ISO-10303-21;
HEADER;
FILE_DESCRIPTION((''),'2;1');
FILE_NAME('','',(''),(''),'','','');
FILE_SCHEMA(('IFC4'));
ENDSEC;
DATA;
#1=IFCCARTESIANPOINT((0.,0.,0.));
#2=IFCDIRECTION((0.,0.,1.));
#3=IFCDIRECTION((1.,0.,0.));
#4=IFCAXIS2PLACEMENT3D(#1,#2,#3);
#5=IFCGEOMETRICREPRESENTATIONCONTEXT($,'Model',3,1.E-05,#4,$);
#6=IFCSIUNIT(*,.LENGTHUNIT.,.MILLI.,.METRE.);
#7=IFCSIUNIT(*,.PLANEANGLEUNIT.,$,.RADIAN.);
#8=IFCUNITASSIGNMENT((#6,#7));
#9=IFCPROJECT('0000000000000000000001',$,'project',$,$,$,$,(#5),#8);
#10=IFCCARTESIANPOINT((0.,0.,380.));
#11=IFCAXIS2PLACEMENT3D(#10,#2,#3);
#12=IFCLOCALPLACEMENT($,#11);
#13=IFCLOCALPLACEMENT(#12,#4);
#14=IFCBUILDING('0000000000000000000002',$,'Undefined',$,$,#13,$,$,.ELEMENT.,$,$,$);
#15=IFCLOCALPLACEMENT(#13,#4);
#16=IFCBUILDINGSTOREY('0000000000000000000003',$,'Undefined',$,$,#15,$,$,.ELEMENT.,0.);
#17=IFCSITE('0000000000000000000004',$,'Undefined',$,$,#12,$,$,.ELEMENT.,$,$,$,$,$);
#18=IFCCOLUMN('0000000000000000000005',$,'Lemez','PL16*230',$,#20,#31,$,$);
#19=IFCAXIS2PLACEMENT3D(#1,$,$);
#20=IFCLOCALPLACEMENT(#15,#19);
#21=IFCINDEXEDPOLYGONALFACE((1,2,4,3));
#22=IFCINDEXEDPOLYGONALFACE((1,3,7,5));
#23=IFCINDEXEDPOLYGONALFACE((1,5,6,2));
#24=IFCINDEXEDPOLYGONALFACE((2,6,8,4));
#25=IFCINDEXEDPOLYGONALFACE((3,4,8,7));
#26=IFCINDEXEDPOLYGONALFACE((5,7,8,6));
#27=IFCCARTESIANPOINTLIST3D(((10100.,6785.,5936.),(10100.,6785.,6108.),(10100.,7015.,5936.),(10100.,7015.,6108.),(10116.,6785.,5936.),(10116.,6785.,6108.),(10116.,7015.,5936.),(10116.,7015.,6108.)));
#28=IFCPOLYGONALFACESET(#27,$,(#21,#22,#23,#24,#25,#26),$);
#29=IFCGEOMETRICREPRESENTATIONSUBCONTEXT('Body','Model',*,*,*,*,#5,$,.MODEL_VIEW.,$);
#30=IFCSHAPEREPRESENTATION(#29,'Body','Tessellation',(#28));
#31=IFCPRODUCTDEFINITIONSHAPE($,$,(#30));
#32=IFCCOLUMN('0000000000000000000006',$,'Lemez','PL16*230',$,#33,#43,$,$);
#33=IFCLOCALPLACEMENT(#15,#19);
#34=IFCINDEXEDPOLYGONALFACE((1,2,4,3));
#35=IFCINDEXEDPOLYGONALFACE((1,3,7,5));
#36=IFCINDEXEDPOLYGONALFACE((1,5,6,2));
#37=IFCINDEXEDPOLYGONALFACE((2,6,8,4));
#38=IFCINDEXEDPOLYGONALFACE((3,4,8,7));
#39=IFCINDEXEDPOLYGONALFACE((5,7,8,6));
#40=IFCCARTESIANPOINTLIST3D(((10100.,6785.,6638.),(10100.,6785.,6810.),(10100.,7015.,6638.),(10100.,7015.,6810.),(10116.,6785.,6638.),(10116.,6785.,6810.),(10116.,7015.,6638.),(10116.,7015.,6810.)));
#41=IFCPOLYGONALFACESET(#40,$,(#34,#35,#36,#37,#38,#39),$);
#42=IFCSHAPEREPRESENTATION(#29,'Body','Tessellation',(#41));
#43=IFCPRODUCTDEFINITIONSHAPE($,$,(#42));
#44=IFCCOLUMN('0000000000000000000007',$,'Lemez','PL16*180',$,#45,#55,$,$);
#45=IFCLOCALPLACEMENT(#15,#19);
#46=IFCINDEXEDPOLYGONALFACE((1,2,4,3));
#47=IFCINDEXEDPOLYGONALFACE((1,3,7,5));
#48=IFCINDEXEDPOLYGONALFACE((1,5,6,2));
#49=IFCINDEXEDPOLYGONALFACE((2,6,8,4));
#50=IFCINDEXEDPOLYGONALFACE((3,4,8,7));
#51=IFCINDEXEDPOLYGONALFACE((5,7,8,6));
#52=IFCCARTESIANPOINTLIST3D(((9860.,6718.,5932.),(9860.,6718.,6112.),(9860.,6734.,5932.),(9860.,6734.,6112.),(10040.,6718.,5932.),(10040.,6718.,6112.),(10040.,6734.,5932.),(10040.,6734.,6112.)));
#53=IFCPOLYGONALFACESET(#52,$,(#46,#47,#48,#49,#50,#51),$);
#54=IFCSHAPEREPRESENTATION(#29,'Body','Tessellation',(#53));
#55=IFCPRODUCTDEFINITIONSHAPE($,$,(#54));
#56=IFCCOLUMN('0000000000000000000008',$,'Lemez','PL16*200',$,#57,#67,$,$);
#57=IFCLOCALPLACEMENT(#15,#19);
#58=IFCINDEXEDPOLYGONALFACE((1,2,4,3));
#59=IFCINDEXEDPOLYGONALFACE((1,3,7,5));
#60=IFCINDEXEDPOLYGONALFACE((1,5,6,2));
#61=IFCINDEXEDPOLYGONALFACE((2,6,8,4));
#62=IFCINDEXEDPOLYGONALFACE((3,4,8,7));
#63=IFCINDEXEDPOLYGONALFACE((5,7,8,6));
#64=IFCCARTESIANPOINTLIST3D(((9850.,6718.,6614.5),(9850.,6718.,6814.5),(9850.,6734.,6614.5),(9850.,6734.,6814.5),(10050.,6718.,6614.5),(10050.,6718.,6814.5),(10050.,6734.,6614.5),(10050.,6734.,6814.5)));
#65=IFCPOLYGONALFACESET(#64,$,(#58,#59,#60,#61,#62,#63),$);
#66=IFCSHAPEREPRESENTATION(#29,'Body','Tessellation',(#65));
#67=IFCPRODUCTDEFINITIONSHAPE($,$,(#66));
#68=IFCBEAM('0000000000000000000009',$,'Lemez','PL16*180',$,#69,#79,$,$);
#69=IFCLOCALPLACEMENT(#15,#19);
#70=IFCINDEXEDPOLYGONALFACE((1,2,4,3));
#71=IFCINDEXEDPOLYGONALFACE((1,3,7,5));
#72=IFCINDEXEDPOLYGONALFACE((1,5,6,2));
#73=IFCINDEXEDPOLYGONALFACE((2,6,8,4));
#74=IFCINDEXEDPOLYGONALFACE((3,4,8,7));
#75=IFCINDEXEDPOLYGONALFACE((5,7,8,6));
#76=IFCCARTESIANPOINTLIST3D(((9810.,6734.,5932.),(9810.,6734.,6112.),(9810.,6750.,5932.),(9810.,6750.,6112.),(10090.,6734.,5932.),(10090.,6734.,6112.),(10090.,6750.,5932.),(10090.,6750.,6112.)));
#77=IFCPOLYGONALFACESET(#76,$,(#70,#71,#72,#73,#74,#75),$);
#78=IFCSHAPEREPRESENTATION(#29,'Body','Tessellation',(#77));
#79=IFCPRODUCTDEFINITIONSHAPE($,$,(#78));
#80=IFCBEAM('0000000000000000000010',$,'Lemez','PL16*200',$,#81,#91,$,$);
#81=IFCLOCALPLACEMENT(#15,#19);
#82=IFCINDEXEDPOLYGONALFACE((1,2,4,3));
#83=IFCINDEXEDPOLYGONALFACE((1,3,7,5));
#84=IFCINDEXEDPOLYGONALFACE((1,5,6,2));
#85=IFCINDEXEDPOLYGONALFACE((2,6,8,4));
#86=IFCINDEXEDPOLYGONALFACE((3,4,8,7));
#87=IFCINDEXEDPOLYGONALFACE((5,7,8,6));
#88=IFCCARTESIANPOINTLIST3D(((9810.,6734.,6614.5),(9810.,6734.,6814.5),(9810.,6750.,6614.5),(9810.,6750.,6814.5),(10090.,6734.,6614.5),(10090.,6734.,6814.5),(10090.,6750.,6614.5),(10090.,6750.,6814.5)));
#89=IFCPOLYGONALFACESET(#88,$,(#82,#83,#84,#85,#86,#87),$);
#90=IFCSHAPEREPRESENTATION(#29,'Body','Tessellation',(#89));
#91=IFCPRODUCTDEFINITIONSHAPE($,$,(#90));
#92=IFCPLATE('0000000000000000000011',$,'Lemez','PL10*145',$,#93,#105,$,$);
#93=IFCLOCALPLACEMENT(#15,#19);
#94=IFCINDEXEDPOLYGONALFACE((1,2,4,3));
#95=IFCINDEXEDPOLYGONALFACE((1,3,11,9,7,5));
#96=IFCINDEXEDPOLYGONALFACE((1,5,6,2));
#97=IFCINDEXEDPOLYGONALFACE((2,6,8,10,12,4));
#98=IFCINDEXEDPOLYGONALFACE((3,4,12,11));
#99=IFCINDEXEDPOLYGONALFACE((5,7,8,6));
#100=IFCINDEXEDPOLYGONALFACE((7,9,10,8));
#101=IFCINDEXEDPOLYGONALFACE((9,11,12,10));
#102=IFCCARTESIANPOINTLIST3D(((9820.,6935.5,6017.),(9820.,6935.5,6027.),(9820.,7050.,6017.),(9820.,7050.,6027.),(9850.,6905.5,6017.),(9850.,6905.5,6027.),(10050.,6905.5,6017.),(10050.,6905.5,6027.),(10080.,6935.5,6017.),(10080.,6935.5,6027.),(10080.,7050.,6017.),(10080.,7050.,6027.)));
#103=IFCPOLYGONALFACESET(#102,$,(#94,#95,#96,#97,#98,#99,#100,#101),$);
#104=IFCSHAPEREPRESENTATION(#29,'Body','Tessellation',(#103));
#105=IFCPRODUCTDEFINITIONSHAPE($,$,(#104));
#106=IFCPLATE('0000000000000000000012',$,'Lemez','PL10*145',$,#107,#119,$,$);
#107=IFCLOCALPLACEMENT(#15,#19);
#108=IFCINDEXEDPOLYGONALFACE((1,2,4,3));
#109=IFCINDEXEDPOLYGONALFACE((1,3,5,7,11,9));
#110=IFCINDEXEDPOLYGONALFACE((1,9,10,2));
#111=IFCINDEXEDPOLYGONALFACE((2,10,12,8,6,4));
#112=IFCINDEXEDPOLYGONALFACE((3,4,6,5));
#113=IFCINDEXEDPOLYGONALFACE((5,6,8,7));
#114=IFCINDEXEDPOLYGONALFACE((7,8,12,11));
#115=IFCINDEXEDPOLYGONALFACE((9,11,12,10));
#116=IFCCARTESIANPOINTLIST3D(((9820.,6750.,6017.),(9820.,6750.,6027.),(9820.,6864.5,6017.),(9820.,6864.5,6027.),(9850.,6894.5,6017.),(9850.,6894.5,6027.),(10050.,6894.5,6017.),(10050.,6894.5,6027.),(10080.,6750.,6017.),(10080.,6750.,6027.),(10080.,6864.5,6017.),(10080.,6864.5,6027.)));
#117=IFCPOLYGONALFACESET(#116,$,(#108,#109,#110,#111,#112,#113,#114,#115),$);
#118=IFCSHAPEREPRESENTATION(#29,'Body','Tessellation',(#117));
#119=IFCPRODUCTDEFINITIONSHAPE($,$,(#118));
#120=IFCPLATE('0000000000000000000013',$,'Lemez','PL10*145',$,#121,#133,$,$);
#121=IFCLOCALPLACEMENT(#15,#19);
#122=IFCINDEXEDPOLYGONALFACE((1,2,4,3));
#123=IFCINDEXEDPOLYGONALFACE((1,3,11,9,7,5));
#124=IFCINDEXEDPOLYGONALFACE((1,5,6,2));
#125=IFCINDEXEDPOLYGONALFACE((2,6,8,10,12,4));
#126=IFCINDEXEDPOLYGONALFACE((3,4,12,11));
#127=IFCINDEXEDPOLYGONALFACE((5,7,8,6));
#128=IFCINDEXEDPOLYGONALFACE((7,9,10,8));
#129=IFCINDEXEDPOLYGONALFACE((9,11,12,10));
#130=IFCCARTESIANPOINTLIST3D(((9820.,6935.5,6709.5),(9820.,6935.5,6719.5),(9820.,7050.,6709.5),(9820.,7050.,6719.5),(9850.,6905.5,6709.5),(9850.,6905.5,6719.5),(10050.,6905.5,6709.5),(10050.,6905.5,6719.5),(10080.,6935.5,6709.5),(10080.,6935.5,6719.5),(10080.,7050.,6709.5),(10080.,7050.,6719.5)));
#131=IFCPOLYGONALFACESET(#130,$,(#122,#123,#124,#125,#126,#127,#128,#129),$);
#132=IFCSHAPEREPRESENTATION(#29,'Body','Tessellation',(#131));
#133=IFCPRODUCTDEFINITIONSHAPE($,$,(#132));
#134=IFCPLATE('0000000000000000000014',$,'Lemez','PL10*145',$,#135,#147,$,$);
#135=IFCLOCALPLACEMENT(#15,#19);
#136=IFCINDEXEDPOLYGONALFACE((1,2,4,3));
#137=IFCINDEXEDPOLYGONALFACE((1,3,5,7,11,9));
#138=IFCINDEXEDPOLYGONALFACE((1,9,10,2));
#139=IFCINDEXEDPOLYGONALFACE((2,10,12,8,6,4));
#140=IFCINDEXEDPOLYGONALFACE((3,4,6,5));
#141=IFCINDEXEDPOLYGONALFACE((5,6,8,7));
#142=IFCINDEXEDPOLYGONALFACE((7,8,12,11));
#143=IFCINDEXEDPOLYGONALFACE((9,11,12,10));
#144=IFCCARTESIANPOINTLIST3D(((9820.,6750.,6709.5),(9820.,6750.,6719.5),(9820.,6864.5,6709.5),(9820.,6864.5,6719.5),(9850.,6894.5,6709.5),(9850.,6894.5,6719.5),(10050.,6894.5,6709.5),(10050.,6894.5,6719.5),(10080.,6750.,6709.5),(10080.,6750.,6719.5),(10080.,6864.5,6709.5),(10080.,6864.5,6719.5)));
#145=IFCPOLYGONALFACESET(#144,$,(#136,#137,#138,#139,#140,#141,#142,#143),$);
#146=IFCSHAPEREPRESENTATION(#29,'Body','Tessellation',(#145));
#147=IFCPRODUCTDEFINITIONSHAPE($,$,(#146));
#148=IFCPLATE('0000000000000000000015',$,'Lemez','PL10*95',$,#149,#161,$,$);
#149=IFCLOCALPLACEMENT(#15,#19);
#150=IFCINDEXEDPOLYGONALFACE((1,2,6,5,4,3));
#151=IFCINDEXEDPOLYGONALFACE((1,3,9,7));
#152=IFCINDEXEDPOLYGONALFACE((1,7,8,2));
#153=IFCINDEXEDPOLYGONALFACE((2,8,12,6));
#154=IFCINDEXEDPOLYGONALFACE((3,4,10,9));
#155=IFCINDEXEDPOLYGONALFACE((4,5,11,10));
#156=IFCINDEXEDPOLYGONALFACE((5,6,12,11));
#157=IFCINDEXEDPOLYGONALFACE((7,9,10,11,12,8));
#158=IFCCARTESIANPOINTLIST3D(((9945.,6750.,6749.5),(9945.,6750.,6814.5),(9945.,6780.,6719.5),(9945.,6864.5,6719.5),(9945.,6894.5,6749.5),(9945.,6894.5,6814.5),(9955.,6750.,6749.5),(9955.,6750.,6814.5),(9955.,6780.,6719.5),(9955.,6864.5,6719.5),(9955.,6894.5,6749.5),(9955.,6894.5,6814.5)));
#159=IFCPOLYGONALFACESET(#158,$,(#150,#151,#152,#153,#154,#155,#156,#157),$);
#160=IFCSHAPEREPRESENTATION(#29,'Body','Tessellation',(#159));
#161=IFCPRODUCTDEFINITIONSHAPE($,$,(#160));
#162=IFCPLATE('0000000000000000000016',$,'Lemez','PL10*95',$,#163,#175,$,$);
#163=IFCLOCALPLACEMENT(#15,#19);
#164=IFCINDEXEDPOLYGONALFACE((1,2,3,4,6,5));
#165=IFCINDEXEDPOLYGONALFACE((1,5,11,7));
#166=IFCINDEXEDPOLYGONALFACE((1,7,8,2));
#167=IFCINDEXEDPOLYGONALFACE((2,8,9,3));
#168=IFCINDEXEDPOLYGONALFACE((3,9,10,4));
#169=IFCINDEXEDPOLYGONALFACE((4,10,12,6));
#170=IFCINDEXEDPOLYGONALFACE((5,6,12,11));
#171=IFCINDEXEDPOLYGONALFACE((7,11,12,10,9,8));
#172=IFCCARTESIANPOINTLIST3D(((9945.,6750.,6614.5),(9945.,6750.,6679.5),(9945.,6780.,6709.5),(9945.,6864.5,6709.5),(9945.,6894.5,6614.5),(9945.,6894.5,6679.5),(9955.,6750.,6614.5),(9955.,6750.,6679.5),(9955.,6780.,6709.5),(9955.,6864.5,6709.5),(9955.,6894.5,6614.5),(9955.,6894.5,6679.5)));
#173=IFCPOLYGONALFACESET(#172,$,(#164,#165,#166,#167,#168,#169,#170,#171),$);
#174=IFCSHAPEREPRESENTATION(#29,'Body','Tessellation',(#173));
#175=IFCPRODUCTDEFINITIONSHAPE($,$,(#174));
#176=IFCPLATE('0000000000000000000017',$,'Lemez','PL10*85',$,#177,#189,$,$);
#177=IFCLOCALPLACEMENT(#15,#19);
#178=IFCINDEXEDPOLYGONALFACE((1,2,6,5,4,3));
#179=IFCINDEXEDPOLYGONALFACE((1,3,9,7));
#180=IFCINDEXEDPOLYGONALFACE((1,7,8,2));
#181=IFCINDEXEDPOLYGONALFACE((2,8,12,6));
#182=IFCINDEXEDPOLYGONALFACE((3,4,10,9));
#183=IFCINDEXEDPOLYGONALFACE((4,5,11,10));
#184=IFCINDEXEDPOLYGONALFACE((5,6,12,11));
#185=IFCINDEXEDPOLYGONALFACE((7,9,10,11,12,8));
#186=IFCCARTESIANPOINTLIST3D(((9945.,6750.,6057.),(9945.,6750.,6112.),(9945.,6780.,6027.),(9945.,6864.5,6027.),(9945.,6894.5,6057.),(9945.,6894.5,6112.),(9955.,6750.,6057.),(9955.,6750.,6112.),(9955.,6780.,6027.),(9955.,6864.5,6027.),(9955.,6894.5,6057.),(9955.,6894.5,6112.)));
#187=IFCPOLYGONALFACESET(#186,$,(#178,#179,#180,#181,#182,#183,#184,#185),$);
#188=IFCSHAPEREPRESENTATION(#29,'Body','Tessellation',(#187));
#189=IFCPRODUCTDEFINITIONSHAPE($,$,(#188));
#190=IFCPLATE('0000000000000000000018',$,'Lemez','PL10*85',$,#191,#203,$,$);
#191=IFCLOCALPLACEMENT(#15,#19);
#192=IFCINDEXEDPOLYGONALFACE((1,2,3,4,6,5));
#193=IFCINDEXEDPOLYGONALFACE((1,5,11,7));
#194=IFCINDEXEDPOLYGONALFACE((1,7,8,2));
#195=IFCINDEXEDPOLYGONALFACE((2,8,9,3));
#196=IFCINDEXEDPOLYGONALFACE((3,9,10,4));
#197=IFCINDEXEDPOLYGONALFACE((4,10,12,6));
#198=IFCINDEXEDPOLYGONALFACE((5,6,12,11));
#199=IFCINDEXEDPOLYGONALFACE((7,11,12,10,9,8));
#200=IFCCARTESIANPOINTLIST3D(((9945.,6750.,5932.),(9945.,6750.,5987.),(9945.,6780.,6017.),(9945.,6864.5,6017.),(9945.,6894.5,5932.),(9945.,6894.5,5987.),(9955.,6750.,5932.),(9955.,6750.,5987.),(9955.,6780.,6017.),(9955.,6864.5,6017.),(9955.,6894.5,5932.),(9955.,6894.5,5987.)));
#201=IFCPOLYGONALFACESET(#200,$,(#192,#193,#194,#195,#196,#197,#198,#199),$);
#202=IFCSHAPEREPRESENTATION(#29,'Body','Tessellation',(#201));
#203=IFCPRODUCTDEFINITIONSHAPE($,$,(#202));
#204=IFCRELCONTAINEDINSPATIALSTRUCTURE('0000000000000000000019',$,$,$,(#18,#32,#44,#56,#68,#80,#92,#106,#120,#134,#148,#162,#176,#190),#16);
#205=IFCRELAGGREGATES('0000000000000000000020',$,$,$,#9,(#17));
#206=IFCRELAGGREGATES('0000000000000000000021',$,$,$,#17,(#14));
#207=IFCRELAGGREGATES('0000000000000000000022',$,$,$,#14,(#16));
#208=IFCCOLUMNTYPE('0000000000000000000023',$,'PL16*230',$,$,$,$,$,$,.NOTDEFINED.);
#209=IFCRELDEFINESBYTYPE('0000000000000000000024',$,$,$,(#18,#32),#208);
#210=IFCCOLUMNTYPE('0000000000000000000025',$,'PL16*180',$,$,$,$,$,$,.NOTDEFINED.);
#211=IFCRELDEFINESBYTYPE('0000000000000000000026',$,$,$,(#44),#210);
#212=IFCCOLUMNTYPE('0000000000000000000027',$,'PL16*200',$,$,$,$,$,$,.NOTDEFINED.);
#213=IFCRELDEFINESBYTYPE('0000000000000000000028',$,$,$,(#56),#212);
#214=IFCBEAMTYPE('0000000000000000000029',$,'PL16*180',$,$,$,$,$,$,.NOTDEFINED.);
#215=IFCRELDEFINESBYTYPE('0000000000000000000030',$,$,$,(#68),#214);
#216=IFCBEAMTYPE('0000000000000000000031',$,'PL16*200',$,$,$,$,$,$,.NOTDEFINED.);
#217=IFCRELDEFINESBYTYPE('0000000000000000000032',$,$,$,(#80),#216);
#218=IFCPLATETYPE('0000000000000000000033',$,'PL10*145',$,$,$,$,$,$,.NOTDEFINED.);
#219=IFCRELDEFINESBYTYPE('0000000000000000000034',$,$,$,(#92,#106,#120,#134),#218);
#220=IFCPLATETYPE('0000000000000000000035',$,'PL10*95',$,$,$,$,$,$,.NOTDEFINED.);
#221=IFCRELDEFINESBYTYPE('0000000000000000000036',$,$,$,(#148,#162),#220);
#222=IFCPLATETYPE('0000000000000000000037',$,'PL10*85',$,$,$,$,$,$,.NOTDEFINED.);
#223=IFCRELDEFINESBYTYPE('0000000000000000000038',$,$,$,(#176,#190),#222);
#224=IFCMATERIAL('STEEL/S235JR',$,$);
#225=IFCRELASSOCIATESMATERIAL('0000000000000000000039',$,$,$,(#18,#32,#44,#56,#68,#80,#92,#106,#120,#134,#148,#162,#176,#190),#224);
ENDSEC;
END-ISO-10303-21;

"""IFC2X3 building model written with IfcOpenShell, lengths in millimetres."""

from ifc_helpers import new_model, si_unit, frame, origin_with_axes, origin_2d_with_axis, place, context, subcontext, project, spatial, polyline, rectangle, outline, extrude, material, type_object, element, save


model = new_model("IFC2X3")

# Units and contexts
model_context = context("Model", 3, precision=1e-05, world=origin_with_axes())
body_context = subcontext(model_context, "Body", "Model", "MODEL_VIEW")
ifc_project = project(units=[si_unit("LENGTHUNIT", "METRE", prefix="MILLI"), si_unit("PLANEANGLEUNIT", "RADIAN")], contexts=[model_context])

# Site, building, storey
site_placement = place(None, frame((0.0, 0.0, 380.0), z_axis=(0.0, 0.0, 1.0), x_axis=(1.0, 0.0, 0.0)))
site = spatial("IfcSite", under=ifc_project, at=site_placement, Name="Undefined", CompositionType="ELEMENT")
building_placement = place(site_placement, origin_with_axes())
building = spatial("IfcBuilding", under=site, at=building_placement, Name="Undefined", CompositionType="ELEMENT")
storey_placement = place(building_placement, origin_with_axes())
storey = spatial("IfcBuildingStorey", under=building, at=storey_placement, Name="Undefined", CompositionType="ELEMENT", Elevation=0.0)

# Columns
ifc_material_1 = material(Name="STEEL/S235JR")
column_type_1 = type_object("IfcColumnType", Name="PL16*230", PredefinedType="NOTDEFINED")
for number, where, z_axis, x_axis, name in (
    (1, (10108.0, 6900.0, 5936.0), (0.0, 0.0, 1.0), (0.0, -1.0, 0.0), "Lemez"),
    (2, (10108.0, 6900.0, 6638.0), (0.0, 0.0, 1.0), (0.0, -1.0, 0.0), "Lemez"),
):
    element("IfcColumn", number, at=place(storey_placement, frame(where, z_axis=z_axis, x_axis=x_axis)), inside=storey, type_object=column_type_1, material=ifc_material_1, Name=name, Description="PL16*230", context=body_context, shape_type="SweptSolid", body=[
        extrude(rectangle(XDim=16.0, YDim=230.0, at=origin_2d_with_axis()), frame((0.0, 0.0, 172.0), z_axis=(0.0, 0.0, -1.0), x_axis=(0.0, 1.0, 0.0)), (0.0, 0.0, 1.0), 172.0),
    ])
column_type_2 = type_object("IfcColumnType", Name="PL16*180", PredefinedType="NOTDEFINED")
column_1_placement = place(storey_placement, frame((9950.0, 6726.0, 5932.0), z_axis=(0.0, 0.0, 1.0), x_axis=(-1.0, 0.0, 0.0)))
element("IfcColumn", 3, at=column_1_placement, inside=storey, type_object=column_type_2, material=ifc_material_1, Name="Lemez", Description="PL16*180", context=body_context, shape_type="SweptSolid", body=[
    extrude(rectangle(XDim=16.0, YDim=180.0, at=origin_2d_with_axis()), frame((0.0, 0.0, 180.0), z_axis=(0.0, 0.0, -1.0), x_axis=(0.0, 1.0, 0.0)), (0.0, 0.0, 1.0), 180.0),
])
column_type_3 = type_object("IfcColumnType", Name="PL16*200", PredefinedType="NOTDEFINED")
column_2_placement = place(storey_placement, frame((9950.0, 6726.0, 6614.5), z_axis=(0.0, 0.0, 1.0), x_axis=(-1.0, 0.0, 0.0)))
element("IfcColumn", 4, at=column_2_placement, inside=storey, type_object=column_type_3, material=ifc_material_1, Name="Lemez", Description="PL16*200", context=body_context, shape_type="SweptSolid", body=[
    extrude(rectangle(XDim=16.0, YDim=200.0, at=origin_2d_with_axis()), frame((0.0, 0.0, 200.0), z_axis=(0.0, 0.0, -1.0), x_axis=(0.0, 1.0, 0.0)), (0.0, 0.0, 1.0), 200.0),
])

# Beams
beam_type_1 = type_object("IfcBeamType", Name="PL16*180", PredefinedType="NOTDEFINED")
beam_1_placement = place(storey_placement, frame((10090.0, 6742.0, 6022.0), z_axis=(0.0, 0.0, -1.0), x_axis=(-1.0, 0.0, 0.0)))
element("IfcBeam", 5, at=beam_1_placement, inside=storey, type_object=beam_type_1, material=ifc_material_1, Name="Lemez", Description="PL16*180", context=body_context, shape_type="SweptSolid", body=[
    extrude(rectangle(XDim=16.0, YDim=180.0, at=origin_2d_with_axis()), frame((280.0, 0.0, 0.0), z_axis=(-1.0, 0.0, 0.0), x_axis=(0.0, -1.0, 0.0)), (0.0, 0.0, 1.0), 280.0),
])
beam_type_2 = type_object("IfcBeamType", Name="PL16*200", PredefinedType="NOTDEFINED")
beam_2_placement = place(storey_placement, frame((10090.0, 6742.0, 6714.5), z_axis=(0.0, 0.0, -1.0), x_axis=(-1.0, 0.0, 0.0)))
element("IfcBeam", 6, at=beam_2_placement, inside=storey, type_object=beam_type_2, material=ifc_material_1, Name="Lemez", Description="PL16*200", context=body_context, shape_type="SweptSolid", body=[
    extrude(rectangle(XDim=16.0, YDim=200.0, at=origin_2d_with_axis()), frame((280.0, 0.0, 0.0), z_axis=(-1.0, 0.0, 0.0), x_axis=(0.0, -1.0, 0.0)), (0.0, 0.0, 1.0), 280.0),
])

# Plates
plate_type_1 = type_object("IfcPlateType", Name="PL10*145", PredefinedType="NOTDEFINED")
for number, where, z_axis, x_axis, name in (
    (7, (10080.0, 6905.5, 6022.0), (0.0, 0.0, 1.0), (0.0, 1.0, 0.0), "Lemez"),
    (8, (10080.0, 6894.5, 6022.0), (0.0, 0.0, -1.0), (0.0, -1.0, 0.0), "Lemez"),
    (9, (10080.0, 6905.5, 6714.5), (0.0, 0.0, 1.0), (0.0, 1.0, 0.0), "Lemez"),
    (10, (10080.0, 6894.5, 6714.5), (0.0, 0.0, -1.0), (0.0, -1.0, 0.0), "Lemez"),
):
    element("IfcPlate", number, at=place(storey_placement, frame(where, z_axis=z_axis, x_axis=x_axis)), inside=storey, type_object=plate_type_1, material=ifc_material_1, Name=name, Description="PL10*145", context=body_context, shape_type="SweptSolid", body=[
        extrude(outline(polyline([(0.0, 30.0), (30.0, 0.0), (144.5, 0.0), (144.5, 260.0), (30.0, 260.0), (0.0, 230.0), (0.0, 30.0)])), frame((0.0, 0.0, -5.0), z_axis=(0.0, 0.0, 1.0), x_axis=(1.0, 0.0, 0.0)), (0.0, 0.0, 1.0), 10.0),
    ])
plate_type_2 = type_object("IfcPlateType", Name="PL10*95", PredefinedType="NOTDEFINED")
plate_1_placement = place(storey_placement, frame((9950.0, 6750.0, 6814.5), z_axis=(-1.0, 0.0, 0.0), x_axis=(0.0, 1.0, 0.0)))
element("IfcPlate", 11, at=plate_1_placement, inside=storey, type_object=plate_type_2, material=ifc_material_1, Name="Lemez", Description="PL10*95", context=body_context, shape_type="SweptSolid", body=[
    extrude(outline(polyline([(0.0, 0.0), (144.5, 0.0), (144.5, 65.0), (114.5, 95.0), (30.0, 95.0), (0.0, 65.0), (0.0, 0.0)])), frame((0.0, 0.0, -5.0), z_axis=(0.0, 0.0, 1.0), x_axis=(1.0, 0.0, 0.0)), (0.0, 0.0, 1.0), 10.0),
])
plate_2_placement = place(storey_placement, frame((9950.0, 6750.0, 6709.5), z_axis=(-1.0, 0.0, 0.0), x_axis=(0.0, 1.0, 0.0)))
element("IfcPlate", 12, at=plate_2_placement, inside=storey, type_object=plate_type_2, material=ifc_material_1, Name="Lemez", Description="PL10*95", context=body_context, shape_type="SweptSolid", body=[
    extrude(outline(polyline([(0.0, 30.0), (30.0, 0.0), (114.5, 0.0), (144.5, 30.0), (144.5, 95.0), (0.0, 95.0), (0.0, 30.0)])), frame((0.0, 0.0, -5.0), z_axis=(0.0, 0.0, 1.0), x_axis=(1.0, 0.0, 0.0)), (0.0, 0.0, 1.0), 10.0),
])
plate_type_3 = type_object("IfcPlateType", Name="PL10*85", PredefinedType="NOTDEFINED")
plate_3_placement = place(storey_placement, frame((9950.0, 6750.0, 6112.0), z_axis=(-1.0, 0.0, 0.0), x_axis=(0.0, 1.0, 0.0)))
element("IfcPlate", 13, at=plate_3_placement, inside=storey, type_object=plate_type_3, material=ifc_material_1, Name="Lemez", Description="PL10*85", context=body_context, shape_type="SweptSolid", body=[
    extrude(outline(polyline([(0.0, 0.0), (144.5, 0.0), (144.5, 55.0), (114.5, 85.0), (30.0, 85.0), (0.0, 55.0), (0.0, 0.0)])), frame((0.0, 0.0, -5.0), z_axis=(0.0, 0.0, 1.0), x_axis=(1.0, 0.0, 0.0)), (0.0, 0.0, 1.0), 10.0),
])
plate_4_placement = place(storey_placement, frame((9950.0, 6750.0, 6017.0), z_axis=(-1.0, 0.0, 0.0), x_axis=(0.0, 1.0, 0.0)))
element("IfcPlate", 14, at=plate_4_placement, inside=storey, type_object=plate_type_3, material=ifc_material_1, Name="Lemez", Description="PL10*85", context=body_context, shape_type="SweptSolid", body=[
    extrude(outline(polyline([(0.0, 30.0), (30.0, 0.0), (114.5, 0.0), (144.5, 30.0), (144.5, 85.0), (0.0, 85.0), (0.0, 30.0)])), frame((0.0, 0.0, -5.0), z_axis=(0.0, 0.0, 1.0), x_axis=(1.0, 0.0, 0.0)), (0.0, 0.0, 1.0), 10.0),
])

save(model, "model.ifc")
